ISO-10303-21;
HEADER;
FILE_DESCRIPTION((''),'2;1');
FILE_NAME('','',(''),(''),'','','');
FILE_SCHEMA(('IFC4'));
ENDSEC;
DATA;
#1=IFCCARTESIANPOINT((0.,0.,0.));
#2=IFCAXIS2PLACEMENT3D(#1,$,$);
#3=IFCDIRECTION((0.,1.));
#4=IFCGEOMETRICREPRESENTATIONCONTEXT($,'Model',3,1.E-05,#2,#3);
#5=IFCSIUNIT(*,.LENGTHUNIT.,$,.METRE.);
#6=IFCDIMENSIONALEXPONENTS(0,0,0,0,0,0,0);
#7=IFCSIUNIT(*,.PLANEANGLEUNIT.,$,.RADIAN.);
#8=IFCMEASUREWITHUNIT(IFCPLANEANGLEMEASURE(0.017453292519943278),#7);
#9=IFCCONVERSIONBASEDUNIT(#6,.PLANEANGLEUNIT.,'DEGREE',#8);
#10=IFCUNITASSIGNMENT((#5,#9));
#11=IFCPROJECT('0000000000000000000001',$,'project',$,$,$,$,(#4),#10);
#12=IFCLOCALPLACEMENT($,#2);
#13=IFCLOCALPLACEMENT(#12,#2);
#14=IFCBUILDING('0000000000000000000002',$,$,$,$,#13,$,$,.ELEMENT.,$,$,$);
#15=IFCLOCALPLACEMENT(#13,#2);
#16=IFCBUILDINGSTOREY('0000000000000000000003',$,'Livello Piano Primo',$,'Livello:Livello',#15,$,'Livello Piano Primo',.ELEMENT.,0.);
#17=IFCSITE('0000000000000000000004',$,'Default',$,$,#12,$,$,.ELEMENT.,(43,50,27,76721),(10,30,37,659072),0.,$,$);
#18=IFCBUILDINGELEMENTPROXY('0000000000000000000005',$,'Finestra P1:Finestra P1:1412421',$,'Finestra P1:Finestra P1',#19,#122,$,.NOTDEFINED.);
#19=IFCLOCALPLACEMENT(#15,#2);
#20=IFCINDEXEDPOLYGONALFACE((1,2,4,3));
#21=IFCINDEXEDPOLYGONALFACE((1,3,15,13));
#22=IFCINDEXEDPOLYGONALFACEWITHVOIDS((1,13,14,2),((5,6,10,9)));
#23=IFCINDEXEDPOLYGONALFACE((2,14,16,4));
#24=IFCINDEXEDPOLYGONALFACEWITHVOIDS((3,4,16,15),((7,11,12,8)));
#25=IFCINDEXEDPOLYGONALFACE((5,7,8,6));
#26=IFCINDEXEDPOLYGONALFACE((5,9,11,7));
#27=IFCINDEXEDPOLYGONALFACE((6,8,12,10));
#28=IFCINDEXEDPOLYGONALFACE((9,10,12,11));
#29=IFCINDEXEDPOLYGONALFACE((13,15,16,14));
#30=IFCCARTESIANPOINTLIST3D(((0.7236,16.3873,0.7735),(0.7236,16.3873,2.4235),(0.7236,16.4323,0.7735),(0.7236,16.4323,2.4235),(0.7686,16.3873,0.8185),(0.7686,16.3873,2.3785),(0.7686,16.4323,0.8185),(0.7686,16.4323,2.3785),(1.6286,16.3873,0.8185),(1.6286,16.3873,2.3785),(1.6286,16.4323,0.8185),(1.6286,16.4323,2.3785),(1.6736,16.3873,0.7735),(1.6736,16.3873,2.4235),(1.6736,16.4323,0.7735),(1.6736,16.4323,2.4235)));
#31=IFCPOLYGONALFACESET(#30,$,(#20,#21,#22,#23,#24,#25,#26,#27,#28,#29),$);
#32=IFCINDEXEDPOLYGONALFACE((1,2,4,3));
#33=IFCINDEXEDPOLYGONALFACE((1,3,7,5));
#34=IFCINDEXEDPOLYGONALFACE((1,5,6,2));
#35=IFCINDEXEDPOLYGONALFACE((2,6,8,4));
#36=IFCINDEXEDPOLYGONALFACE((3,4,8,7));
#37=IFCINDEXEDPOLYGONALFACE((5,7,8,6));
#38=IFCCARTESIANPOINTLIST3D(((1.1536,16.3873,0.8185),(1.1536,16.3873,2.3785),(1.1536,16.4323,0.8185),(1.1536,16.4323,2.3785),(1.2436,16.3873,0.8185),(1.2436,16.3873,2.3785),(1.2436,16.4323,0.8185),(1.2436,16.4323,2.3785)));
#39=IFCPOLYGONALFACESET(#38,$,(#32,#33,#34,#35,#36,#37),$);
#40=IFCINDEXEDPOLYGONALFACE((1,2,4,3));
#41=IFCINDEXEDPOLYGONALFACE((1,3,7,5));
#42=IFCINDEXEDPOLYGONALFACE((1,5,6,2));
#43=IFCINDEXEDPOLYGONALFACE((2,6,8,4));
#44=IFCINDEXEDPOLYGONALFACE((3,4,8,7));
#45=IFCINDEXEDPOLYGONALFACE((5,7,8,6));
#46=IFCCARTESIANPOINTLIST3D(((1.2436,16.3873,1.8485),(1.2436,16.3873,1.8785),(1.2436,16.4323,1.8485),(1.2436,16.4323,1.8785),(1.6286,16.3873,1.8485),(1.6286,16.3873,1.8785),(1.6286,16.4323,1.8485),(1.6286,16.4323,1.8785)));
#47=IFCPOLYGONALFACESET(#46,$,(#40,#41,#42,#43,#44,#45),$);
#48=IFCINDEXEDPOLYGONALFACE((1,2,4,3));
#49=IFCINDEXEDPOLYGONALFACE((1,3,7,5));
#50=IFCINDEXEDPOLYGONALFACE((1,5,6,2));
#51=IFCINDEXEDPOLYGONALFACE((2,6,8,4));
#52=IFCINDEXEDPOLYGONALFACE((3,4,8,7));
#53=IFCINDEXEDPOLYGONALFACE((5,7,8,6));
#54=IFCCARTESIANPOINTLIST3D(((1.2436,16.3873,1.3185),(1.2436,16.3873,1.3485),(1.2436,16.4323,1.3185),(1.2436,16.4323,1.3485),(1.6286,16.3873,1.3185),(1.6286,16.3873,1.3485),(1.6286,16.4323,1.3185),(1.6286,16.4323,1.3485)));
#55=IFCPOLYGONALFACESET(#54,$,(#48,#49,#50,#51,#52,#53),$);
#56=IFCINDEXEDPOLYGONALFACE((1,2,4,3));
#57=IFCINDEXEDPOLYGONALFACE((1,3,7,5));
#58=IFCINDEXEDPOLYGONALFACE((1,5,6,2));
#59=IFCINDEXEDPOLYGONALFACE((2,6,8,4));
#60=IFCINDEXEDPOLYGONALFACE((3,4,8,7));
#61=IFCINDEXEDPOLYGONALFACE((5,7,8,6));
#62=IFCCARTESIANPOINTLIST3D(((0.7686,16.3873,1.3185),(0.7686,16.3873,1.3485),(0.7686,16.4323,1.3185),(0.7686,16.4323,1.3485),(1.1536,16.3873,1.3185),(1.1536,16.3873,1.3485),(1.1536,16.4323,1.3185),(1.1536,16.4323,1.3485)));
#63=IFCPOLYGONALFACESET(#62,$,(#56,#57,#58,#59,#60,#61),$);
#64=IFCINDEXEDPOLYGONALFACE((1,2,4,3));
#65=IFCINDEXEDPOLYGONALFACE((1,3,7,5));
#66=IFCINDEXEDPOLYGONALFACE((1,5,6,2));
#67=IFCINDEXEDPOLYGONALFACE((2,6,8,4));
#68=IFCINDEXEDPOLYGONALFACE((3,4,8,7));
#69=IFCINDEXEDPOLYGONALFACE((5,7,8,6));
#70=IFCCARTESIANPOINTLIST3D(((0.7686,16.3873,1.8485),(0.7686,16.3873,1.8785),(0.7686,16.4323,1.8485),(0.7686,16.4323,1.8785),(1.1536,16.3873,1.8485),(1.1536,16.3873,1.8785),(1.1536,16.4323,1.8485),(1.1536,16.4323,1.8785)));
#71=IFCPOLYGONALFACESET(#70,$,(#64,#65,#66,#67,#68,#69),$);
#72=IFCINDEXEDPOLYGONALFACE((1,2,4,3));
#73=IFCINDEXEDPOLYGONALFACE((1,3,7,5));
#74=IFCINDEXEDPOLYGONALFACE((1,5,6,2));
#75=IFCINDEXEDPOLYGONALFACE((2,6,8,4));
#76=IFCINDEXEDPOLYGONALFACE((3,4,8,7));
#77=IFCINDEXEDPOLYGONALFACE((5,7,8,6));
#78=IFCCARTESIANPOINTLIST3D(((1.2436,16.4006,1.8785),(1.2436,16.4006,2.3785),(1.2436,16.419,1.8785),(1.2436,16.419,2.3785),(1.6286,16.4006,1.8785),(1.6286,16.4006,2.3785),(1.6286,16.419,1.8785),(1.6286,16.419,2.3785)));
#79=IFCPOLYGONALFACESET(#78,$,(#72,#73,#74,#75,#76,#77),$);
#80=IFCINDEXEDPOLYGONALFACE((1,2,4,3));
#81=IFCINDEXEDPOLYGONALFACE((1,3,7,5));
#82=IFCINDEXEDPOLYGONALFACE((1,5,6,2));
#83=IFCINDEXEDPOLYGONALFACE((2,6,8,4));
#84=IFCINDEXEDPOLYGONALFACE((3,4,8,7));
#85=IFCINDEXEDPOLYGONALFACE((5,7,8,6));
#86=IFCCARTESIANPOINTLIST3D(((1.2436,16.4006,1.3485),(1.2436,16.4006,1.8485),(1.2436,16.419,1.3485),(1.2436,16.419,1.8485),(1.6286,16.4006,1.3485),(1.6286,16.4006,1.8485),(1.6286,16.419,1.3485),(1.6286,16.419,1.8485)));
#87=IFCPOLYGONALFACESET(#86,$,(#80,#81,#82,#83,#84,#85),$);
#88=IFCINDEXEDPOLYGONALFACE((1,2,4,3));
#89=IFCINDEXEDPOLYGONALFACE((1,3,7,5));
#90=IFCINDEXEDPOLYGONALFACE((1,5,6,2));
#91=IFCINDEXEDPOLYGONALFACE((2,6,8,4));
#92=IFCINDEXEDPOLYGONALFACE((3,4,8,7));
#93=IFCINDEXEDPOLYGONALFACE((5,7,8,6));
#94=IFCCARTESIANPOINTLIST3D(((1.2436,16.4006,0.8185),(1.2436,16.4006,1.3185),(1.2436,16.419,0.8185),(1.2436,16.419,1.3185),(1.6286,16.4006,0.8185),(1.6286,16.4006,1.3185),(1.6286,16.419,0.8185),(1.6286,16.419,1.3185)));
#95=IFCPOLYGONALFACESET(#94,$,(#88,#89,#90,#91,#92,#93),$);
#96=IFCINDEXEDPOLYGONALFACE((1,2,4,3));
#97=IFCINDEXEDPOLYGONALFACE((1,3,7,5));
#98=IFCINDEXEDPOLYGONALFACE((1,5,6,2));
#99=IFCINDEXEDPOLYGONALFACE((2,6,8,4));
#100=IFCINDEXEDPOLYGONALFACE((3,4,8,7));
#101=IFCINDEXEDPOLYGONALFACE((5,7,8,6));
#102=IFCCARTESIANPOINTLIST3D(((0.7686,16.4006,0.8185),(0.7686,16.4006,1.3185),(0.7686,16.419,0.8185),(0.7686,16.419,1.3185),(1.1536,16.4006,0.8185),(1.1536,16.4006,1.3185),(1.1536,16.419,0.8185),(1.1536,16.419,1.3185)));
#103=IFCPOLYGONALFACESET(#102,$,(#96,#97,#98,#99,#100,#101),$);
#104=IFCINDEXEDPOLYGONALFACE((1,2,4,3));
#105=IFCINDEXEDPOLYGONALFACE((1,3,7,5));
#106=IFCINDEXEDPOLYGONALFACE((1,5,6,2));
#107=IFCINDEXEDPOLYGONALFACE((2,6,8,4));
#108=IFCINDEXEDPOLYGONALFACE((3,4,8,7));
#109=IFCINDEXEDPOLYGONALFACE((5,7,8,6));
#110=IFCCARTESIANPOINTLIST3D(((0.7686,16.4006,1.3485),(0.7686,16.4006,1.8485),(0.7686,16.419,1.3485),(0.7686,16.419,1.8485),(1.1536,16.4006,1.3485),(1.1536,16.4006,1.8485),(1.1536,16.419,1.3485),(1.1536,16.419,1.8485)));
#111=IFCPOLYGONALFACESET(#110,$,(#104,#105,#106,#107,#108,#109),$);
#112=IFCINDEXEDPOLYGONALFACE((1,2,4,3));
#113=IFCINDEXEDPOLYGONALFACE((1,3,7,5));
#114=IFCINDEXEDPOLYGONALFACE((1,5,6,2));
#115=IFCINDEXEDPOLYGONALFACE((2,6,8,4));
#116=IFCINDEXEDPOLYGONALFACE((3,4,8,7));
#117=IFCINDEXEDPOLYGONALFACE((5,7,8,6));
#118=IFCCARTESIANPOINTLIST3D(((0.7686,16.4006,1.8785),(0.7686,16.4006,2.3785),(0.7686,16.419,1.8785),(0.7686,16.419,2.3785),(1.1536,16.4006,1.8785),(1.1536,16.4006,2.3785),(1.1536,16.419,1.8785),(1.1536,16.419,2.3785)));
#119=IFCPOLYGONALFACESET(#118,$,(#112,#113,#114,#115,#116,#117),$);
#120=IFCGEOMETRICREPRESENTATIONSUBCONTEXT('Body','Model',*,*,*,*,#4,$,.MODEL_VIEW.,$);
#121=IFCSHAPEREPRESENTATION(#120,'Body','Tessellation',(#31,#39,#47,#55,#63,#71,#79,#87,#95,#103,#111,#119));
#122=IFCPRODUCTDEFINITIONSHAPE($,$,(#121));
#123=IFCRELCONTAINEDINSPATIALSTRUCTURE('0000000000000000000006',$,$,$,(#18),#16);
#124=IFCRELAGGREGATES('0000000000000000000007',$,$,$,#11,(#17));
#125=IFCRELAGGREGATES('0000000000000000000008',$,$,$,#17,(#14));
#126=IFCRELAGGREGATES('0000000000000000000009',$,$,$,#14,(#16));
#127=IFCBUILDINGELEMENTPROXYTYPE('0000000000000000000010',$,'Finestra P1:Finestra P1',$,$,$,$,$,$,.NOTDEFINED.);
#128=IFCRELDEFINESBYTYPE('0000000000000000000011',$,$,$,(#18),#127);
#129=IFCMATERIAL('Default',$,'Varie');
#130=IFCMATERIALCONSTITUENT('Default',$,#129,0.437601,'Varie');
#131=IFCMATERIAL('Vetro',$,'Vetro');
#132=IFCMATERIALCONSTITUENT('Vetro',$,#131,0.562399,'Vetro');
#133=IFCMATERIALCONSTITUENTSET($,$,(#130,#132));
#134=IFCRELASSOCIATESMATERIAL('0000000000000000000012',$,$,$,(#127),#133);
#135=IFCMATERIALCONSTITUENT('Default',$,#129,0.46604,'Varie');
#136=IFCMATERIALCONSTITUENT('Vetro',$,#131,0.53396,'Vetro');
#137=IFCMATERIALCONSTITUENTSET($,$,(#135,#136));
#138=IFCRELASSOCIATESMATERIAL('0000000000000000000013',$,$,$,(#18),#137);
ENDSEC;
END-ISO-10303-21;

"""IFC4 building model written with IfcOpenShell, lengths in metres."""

from ifc_helpers import new_model, entity, si_unit, converted_unit, direction, frame, origin, place, context, subcontext, project, spatial, indexed_curve, outline, extrude, source, transform, mapped, material, constituent, constituent_set, type_object, type_shapes, element, save


model = new_model("IFC4")

# Units and contexts
model_context = context("Model", 3, precision=1e-05, world=origin(), true_north=direction((0.0, 1.0)))
body_context = subcontext(model_context, "Body", "Model", "MODEL_VIEW")
ifc_project = project(units=[si_unit("LENGTHUNIT", "METRE"), converted_unit("PLANEANGLEUNIT", "DEGREE", entity("IfcPlaneAngleMeasure", 0.017453292519943278), si_unit("PLANEANGLEUNIT", "RADIAN"), dimensions=[0, 0, 0, 0, 0, 0, 0])], contexts=[model_context])

# Site, building, storey
site_placement = place(None, origin())
site = spatial("IfcSite", under=ifc_project, at=site_placement, Name="Default", CompositionType="ELEMENT", RefLatitude=(43, 50, 27, 76721), RefLongitude=(10, 30, 37, 659072), RefElevation=0.0)
building_placement = place(site_placement, origin())
building = spatial("IfcBuilding", under=site, at=building_placement, CompositionType="ELEMENT")
storey_placement = place(building_placement, origin())
storey = spatial("IfcBuildingStorey", under=building, at=storey_placement, Name="Livello Piano Primo", ObjectType="Livello:Livello", LongName="Livello Piano Primo", CompositionType="ELEMENT", Elevation=0.0)

# Building element proxy
ifc_material_1 = material(Name="Default", Category="Varie")
ifc_material_2 = material(Name="Vetro", Category="Vetro")
ifc_constituent_1 = constituent(ifc_material_1, Name="Default", Category="Varie", fraction=0.437601)
ifc_constituent_2 = constituent(ifc_material_2, Name="Vetro", Category="Vetro", fraction=0.562399)
ifc_constituent_set_1 = constituent_set(constituents=[ifc_constituent_1, ifc_constituent_2])
building_element_proxy_type_1 = type_object("IfcBuildingElementProxyType", Name="Finestra P1:Finestra P1", PredefinedType="NOTDEFINED", material=ifc_constituent_set_1)
shared_shape_1 = source(origin(), body_context, "Body", "SweptSolid", [
    extrude(outline(indexed_curve([(-0.825, -0.475), (0.825, -0.475), (0.825, 0.475), (-0.825, 0.475), (-0.825, -0.475)], self_intersect=False), holes=[indexed_curve([(0.78, -0.43), (-0.78, -0.43), (-0.78, 0.43), (0.78, 0.43), (0.78, -0.43)], self_intersect=False)]), frame((0.0, -0.0225, 0.825), z_axis=(0.0, 1.0, 0.0), x_axis=(0.0, 0.0, -1.0)), (0.0, 0.0, 1.0), 0.045),
    extrude(outline(indexed_curve([(-0.045, -0.0225), (0.045, -0.0225), (0.045, 0.0225), (-0.045, 0.0225), (-0.045, -0.0225)], self_intersect=False)), frame((0.0, 0.0, 0.045), z_axis=(0.0, 0.0, 1.0), x_axis=(-1.0, 0.0, 0.0)), (0.0, 0.0, 1.0), 1.56),
    extrude(outline(indexed_curve([(-0.1925, -0.0225), (0.1925, -0.0225), (0.1925, 0.0225), (-0.1925, 0.0225), (-0.1925, -0.0225)], self_intersect=False)), frame((0.2375, 0.0, 1.075)), (0.0, 0.0, 1.0), 0.03),
    extrude(outline(indexed_curve([(-0.1925, -0.0225), (0.1925, -0.0225), (0.1925, 0.0225), (-0.1925, 0.0225), (-0.1925, -0.0225)], self_intersect=False)), frame((0.2375, 0.0, 0.545)), (0.0, 0.0, 1.0), 0.03),
    extrude(outline(indexed_curve([(-0.1925, -0.0225), (0.1925, -0.0225), (0.1925, 0.0225), (-0.1925, 0.0225), (-0.1925, -0.0225)], self_intersect=False)), frame((-0.2375, 0.0, 0.545)), (0.0, 0.0, 1.0), 0.03),
    extrude(outline(indexed_curve([(-0.1925, -0.0225), (0.1925, -0.0225), (0.1925, 0.0225), (-0.1925, 0.0225), (-0.1925, -0.0225)], self_intersect=False)), frame((-0.2375, 0.0, 1.075)), (0.0, 0.0, 1.0), 0.03),
    extrude(outline(indexed_curve([(-0.1925, -0.0092), (0.1925, -0.0092), (0.1925, 0.0092), (-0.1925, 0.0092), (-0.1925, -0.0092)], self_intersect=False)), frame((0.2375, 0.0, 1.105), z_axis=(0.0, 0.0, 1.0), x_axis=(-1.0, 0.0, 0.0)), (0.0, 0.0, 1.0), 0.5),
    extrude(outline(indexed_curve([(-0.1925, -0.0092), (0.1925, -0.0092), (0.1925, 0.0092), (-0.1925, 0.0092), (-0.1925, -0.0092)], self_intersect=False)), frame((0.2375, 0.0, 0.575), z_axis=(0.0, 0.0, 1.0), x_axis=(-1.0, 0.0, 0.0)), (0.0, 0.0, 1.0), 0.5),
    extrude(outline(indexed_curve([(-0.1925, -0.0092), (0.1925, -0.0092), (0.1925, 0.0092), (-0.1925, 0.0092), (-0.1925, -0.0092)], self_intersect=False)), frame((0.2375, 0.0, 0.045), z_axis=(0.0, 0.0, 1.0), x_axis=(-1.0, 0.0, 0.0)), (0.0, 0.0, 1.0), 0.5),
    extrude(outline(indexed_curve([(-0.1925, -0.0092), (0.1925, -0.0092), (0.1925, 0.0092), (-0.1925, 0.0092), (-0.1925, -0.0092)], self_intersect=False)), frame((-0.2375, 0.0, 0.045), z_axis=(0.0, 0.0, 1.0), x_axis=(-1.0, 0.0, 0.0)), (0.0, 0.0, 1.0), 0.5),
    extrude(outline(indexed_curve([(-0.1925, -0.0092), (0.1925, -0.0092), (0.1925, 0.0092), (-0.1925, 0.0092), (-0.1925, -0.0092)], self_intersect=False)), frame((-0.2375, 0.0, 0.575), z_axis=(0.0, 0.0, 1.0), x_axis=(-1.0, 0.0, 0.0)), (0.0, 0.0, 1.0), 0.5),
    extrude(outline(indexed_curve([(-0.1925, -0.0092), (0.1925, -0.0092), (0.1925, 0.0092), (-0.1925, 0.0092), (-0.1925, -0.0092)], self_intersect=False)), frame((-0.2375, 0.0, 1.105), z_axis=(0.0, 0.0, 1.0), x_axis=(-1.0, 0.0, 0.0)), (0.0, 0.0, 1.0), 0.5),
])
type_shapes(building_element_proxy_type_1, [shared_shape_1])
ifc_constituent_3 = constituent(ifc_material_1, Name="Default", Category="Varie", fraction=0.46604)
ifc_constituent_4 = constituent(ifc_material_2, Name="Vetro", Category="Vetro", fraction=0.53396)
ifc_constituent_set_2 = constituent_set(constituents=[ifc_constituent_3, ifc_constituent_4])
proxy_1_placement = place(storey_placement, frame((1.1986, 16.4098, 0.7735)))
element("IfcBuildingElementProxy", 1, at=proxy_1_placement, inside=storey, type_object=building_element_proxy_type_1, material=ifc_constituent_set_2, Name="Finestra P1:Finestra P1:1412421", ObjectType="Finestra P1:Finestra P1", PredefinedType="NOTDEFINED", context=body_context, shape_type="MappedRepresentation", body=[
    mapped(shared_shape_1, transform((0.0, 0.0, 0.0), scale=1.0)),
])

save(model, "model.ifc")
